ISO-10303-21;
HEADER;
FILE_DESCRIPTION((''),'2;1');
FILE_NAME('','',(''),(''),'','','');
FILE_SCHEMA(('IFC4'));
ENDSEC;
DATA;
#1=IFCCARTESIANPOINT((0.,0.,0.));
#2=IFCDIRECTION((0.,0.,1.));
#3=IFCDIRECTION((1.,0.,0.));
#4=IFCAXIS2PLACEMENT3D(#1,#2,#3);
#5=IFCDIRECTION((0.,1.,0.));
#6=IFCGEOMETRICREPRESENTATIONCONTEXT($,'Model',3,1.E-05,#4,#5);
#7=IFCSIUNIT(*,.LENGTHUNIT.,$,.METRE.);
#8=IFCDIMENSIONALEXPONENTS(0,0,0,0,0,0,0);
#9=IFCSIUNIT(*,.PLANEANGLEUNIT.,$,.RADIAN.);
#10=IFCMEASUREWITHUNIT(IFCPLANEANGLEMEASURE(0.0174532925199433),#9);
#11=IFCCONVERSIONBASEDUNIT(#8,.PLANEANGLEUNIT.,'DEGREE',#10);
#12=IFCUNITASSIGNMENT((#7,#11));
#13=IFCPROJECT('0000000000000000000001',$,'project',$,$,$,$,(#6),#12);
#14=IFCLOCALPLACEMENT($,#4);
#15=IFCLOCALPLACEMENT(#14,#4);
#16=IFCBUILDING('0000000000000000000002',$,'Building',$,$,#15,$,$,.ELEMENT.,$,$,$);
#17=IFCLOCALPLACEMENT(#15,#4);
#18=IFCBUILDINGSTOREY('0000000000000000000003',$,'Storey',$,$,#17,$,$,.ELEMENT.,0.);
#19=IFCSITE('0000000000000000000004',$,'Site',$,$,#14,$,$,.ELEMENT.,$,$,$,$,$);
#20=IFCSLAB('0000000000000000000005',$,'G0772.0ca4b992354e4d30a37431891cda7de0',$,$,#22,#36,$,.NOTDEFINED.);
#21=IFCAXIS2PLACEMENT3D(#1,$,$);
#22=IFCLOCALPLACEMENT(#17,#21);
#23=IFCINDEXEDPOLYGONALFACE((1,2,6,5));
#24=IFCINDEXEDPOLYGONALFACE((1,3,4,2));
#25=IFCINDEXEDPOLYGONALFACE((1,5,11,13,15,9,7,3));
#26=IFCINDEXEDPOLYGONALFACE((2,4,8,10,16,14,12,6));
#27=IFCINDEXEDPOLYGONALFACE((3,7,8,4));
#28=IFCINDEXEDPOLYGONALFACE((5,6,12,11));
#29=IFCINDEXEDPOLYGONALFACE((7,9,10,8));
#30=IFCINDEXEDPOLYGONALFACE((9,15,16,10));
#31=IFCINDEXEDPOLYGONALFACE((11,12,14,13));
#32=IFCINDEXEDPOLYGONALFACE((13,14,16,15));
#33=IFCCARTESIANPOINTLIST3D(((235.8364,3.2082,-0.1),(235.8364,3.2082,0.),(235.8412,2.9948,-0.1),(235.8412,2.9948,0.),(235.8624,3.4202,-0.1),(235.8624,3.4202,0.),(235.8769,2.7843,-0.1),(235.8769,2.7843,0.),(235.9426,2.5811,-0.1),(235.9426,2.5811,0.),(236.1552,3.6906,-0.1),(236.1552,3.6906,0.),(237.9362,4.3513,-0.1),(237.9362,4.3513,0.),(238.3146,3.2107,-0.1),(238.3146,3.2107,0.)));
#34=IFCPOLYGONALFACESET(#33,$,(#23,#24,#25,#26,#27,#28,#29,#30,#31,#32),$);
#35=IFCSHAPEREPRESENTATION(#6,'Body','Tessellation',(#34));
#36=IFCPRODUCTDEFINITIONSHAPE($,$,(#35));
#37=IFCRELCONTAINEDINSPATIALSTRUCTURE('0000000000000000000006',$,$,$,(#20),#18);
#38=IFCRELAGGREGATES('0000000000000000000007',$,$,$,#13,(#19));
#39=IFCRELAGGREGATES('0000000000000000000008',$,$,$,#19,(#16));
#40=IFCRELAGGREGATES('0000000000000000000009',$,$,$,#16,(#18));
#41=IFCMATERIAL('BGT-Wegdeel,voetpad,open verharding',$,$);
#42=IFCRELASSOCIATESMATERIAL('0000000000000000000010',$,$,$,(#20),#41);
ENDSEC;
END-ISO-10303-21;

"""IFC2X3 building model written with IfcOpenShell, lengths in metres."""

from ifc_helpers import new_model, entity, si_unit, converted_unit, direction, frame, origin_with_axes, place, context, project, spatial, polyline, outline, extrude, material, element, save


model = new_model("IFC2X3")

# Units and contexts
model_context = context("Model", 3, precision=1e-05, world=origin_with_axes(), true_north=direction((0.0, 1.0, 0.0)))
ifc_project = project(units=[si_unit("LENGTHUNIT", "METRE"), converted_unit("PLANEANGLEUNIT", "DEGREE", entity("IfcPlaneAngleMeasure", 0.0174532925199433), si_unit("PLANEANGLEUNIT", "RADIAN"), dimensions=[0, 0, 0, 0, 0, 0, 0])], contexts=[model_context])

# Site, building, storey
site_placement = place(None, origin_with_axes())
site = spatial("IfcSite", under=ifc_project, at=site_placement, Name="Site", CompositionType="ELEMENT")
building_placement = place(site_placement, origin_with_axes())
building = spatial("IfcBuilding", under=site, at=building_placement, Name="Building", CompositionType="ELEMENT")
storey_placement = place(building_placement, origin_with_axes())
storey = spatial("IfcBuildingStorey", under=building, at=storey_placement, Name="Storey", CompositionType="ELEMENT", Elevation=0.0)

# Slab
ifc_material_1 = material(Name="BGT-Wegdeel,voetpad,open verharding")
slab_1_placement = place(storey_placement, frame((0.0, 0.0, -0.1), z_axis=(0.0, 0.0, 1.0), x_axis=(1.0, 0.0, 0.0)))
element("IfcSlab", 1, at=slab_1_placement, inside=storey, material=ifc_material_1, Name="G0772.0ca4b992354e4d30a37431891cda7de0", PredefinedType="NOTDEFINED", context=model_context, shape_type="SweptSolid", body=[
    extrude(outline(polyline([(236.1552, 3.6906), (237.9362, 4.3513), (238.3146, 3.2107), (235.9426, 2.5811), (235.8769, 2.7843), (235.8412, 2.9948), (235.8364, 3.2082), (235.8624, 3.4202), (236.1552, 3.6906)])), origin_with_axes(), (0.0, 0.0, 1.0), 0.1),
])

save(model, "model.ifc")
